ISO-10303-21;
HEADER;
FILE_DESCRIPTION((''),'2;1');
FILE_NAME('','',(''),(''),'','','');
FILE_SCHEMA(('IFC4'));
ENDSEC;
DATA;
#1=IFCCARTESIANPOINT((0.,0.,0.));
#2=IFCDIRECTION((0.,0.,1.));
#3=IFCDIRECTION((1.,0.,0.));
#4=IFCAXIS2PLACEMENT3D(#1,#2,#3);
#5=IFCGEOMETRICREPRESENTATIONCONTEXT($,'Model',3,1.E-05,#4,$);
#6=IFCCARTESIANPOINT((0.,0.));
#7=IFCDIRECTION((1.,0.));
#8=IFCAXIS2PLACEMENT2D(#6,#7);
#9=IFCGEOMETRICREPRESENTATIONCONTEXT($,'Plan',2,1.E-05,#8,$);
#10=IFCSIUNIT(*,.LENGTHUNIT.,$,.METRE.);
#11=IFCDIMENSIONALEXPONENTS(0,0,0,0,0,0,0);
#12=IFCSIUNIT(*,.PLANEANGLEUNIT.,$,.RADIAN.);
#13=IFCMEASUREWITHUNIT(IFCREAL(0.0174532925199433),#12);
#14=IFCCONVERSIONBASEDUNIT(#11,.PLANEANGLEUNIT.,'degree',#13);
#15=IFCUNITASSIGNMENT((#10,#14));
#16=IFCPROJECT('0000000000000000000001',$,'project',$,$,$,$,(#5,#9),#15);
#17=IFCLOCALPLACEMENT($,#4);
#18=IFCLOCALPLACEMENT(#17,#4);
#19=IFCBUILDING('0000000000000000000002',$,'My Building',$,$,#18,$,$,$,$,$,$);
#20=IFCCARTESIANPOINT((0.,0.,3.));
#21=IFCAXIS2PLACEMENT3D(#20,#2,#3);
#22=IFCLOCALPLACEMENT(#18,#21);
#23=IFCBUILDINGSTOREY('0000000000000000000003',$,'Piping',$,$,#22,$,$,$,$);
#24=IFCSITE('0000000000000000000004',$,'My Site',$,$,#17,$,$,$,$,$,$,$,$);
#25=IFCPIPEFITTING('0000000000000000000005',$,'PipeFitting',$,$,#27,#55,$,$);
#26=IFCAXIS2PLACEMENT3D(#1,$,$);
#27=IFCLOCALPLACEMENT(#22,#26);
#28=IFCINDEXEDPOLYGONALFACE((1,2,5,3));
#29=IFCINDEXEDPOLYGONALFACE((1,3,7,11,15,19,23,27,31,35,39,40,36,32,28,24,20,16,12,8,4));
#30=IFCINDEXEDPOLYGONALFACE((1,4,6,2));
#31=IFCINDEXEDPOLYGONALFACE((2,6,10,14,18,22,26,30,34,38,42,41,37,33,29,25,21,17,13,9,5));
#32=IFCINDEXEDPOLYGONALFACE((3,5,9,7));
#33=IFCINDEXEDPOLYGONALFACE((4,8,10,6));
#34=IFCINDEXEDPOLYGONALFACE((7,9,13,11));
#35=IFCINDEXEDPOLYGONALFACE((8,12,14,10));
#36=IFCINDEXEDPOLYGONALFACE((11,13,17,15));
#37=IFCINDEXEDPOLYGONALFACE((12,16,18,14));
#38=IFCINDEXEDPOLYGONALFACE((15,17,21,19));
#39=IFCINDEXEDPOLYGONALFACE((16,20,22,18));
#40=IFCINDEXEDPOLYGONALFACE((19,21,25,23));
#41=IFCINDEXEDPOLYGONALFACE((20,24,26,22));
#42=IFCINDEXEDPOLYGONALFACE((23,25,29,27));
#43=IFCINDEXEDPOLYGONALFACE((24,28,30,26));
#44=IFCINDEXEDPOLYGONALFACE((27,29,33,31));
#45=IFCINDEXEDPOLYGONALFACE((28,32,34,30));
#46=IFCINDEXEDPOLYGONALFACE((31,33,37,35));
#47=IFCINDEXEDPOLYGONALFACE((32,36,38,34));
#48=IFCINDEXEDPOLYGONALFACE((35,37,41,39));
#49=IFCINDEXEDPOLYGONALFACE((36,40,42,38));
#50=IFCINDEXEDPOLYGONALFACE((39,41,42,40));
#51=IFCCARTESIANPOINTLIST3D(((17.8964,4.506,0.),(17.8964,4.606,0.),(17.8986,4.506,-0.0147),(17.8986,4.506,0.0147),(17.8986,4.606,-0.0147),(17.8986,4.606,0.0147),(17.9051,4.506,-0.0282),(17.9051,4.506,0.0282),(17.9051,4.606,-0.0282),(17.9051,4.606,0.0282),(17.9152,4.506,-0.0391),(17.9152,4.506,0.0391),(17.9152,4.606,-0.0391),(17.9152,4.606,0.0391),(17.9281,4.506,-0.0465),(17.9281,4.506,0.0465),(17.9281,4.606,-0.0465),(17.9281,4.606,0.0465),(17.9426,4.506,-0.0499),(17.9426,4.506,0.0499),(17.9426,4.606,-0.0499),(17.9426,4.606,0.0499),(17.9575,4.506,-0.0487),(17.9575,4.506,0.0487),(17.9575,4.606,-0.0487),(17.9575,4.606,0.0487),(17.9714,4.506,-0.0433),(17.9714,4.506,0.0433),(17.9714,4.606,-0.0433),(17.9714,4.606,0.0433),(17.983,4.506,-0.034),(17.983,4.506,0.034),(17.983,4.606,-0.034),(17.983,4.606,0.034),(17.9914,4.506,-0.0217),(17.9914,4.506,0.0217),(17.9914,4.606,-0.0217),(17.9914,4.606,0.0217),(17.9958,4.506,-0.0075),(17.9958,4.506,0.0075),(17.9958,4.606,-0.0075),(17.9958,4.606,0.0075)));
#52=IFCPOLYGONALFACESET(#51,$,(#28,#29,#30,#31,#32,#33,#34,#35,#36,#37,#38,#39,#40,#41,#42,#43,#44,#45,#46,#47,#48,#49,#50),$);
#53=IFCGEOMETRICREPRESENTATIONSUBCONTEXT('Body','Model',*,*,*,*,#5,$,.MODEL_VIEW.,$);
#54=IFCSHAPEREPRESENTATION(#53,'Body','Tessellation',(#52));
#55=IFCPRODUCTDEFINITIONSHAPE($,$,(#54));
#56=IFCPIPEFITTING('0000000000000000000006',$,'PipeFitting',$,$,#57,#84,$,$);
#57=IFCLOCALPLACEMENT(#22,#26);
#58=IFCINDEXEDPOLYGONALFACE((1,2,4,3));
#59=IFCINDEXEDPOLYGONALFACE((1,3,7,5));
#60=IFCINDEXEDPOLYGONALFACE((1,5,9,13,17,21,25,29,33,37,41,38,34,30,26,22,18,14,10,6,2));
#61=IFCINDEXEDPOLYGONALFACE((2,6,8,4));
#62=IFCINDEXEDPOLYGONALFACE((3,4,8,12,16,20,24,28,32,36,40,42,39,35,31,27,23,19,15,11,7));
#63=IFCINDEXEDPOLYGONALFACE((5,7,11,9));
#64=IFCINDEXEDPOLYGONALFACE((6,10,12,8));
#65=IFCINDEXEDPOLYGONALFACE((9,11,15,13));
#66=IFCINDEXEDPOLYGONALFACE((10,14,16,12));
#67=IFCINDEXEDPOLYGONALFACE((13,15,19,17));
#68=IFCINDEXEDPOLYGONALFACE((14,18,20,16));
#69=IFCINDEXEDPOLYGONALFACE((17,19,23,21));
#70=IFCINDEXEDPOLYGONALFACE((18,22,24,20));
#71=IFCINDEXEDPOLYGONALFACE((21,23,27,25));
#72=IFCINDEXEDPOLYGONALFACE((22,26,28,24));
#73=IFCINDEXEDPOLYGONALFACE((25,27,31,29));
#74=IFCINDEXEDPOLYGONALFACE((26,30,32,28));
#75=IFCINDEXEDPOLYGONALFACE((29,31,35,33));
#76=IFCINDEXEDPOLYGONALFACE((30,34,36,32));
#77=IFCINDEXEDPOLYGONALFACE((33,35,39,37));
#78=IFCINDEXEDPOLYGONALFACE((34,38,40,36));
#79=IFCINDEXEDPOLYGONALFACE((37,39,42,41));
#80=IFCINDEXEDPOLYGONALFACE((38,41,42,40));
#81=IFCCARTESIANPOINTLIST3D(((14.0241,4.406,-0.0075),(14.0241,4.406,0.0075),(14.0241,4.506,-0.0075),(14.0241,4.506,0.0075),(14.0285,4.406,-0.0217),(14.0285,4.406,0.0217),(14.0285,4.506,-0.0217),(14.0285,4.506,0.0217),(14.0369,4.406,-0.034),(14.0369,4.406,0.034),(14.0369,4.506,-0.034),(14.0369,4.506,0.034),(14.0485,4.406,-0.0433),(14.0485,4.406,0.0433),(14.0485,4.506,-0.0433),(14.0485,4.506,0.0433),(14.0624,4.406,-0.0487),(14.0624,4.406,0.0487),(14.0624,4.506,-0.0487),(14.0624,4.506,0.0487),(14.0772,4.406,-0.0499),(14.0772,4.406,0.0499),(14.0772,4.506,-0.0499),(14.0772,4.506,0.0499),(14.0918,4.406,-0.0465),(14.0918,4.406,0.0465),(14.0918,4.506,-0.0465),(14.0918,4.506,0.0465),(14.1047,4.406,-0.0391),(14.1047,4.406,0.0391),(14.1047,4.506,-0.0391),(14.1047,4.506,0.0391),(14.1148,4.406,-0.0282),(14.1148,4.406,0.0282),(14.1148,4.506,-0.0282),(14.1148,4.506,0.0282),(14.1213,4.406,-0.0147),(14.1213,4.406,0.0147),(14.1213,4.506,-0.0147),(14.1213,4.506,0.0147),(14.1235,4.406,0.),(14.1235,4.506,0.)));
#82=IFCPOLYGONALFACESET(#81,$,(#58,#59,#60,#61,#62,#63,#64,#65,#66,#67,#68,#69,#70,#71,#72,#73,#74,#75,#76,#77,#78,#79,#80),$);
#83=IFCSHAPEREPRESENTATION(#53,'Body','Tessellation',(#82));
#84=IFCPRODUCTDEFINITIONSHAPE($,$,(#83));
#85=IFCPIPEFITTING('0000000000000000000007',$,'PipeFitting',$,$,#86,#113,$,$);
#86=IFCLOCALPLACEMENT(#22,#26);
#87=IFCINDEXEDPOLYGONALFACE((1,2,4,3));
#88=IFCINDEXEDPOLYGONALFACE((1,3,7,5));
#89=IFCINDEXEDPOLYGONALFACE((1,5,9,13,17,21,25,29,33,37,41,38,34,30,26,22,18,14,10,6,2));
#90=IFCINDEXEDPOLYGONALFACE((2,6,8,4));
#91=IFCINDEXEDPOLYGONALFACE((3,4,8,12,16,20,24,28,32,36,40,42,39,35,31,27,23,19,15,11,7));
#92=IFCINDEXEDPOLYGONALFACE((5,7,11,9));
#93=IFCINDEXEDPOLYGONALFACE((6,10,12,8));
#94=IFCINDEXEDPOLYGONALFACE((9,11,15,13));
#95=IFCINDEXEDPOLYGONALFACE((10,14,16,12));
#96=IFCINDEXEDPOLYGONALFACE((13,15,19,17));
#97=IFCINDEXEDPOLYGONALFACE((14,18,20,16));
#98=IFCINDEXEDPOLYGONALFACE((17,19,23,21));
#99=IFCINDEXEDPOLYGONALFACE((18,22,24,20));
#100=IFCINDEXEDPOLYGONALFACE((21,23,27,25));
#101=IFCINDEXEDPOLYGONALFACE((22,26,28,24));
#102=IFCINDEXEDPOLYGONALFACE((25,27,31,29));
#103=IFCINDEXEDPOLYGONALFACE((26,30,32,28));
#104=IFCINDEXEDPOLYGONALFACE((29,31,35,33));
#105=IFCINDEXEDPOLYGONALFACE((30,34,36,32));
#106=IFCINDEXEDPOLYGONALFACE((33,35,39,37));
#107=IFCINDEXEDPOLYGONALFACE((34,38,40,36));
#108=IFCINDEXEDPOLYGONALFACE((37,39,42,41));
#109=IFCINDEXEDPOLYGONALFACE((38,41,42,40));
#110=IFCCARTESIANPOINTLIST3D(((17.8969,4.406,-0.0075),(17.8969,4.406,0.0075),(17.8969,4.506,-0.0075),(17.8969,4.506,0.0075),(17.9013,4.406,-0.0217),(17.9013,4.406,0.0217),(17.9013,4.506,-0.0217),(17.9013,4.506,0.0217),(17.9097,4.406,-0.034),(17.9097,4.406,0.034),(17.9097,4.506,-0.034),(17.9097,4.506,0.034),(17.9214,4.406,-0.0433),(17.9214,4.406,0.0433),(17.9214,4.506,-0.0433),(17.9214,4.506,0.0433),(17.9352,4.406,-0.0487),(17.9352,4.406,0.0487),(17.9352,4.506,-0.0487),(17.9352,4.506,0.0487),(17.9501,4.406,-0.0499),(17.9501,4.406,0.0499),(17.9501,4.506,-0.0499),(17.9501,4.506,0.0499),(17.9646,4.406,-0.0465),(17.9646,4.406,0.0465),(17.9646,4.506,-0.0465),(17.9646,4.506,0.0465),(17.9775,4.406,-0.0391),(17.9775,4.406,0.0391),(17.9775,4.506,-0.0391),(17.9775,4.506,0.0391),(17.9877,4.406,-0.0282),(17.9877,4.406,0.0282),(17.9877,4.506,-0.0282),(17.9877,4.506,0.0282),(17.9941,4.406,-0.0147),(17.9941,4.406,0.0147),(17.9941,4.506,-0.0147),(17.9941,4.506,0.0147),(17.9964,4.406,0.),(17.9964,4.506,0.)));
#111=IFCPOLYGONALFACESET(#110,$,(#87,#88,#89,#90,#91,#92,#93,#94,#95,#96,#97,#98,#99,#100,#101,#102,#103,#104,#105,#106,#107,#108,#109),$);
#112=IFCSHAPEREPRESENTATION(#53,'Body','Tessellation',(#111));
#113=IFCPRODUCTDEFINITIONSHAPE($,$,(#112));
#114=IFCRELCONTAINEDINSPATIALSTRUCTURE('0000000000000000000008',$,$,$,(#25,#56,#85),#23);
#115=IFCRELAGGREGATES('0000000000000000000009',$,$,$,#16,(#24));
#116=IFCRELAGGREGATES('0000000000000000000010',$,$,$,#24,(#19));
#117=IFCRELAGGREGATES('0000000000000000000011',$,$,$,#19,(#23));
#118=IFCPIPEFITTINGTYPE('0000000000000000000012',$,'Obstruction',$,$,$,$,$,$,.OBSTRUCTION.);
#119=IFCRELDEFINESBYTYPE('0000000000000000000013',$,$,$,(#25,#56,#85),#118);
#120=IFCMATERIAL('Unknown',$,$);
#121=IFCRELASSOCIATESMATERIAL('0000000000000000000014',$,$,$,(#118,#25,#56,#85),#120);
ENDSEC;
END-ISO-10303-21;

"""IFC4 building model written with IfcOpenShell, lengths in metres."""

from ifc_helpers import new_model, entity, si_unit, converted_unit, frame, origin_with_axes, origin_2d_with_axis, place, context, subcontext, project, spatial, circle, extrude, material, material_profile, profile_set, profile_usage, type_object, element, save


model = new_model("IFC4")

# Units and contexts
model_context = context("Model", 3, precision=1e-05, world=origin_with_axes())
plan_context = context("Plan", 2, precision=1e-05, world=origin_2d_with_axis())
body_context = subcontext(model_context, "Body", "Model", "MODEL_VIEW")
ifc_project = project(units=[si_unit("LENGTHUNIT", "METRE"), converted_unit("PLANEANGLEUNIT", "degree", entity("IfcReal", 0.0174532925199433), si_unit("PLANEANGLEUNIT", "RADIAN"), dimensions=[0, 0, 0, 0, 0, 0, 0])], contexts=[model_context, plan_context])

# Site, building, storey
site_placement = place(None, origin_with_axes())
site = spatial("IfcSite", under=ifc_project, at=site_placement, Name="My Site")
building_placement = place(site_placement, origin_with_axes())
building = spatial("IfcBuilding", under=site, at=building_placement, Name="My Building")
storey_placement = place(building_placement, frame((0.0, 0.0, 3.0), z_axis=(0.0, 0.0, 1.0), x_axis=(1.0, 0.0, 0.0)))
storey = spatial("IfcBuildingStorey", under=building, at=storey_placement, Name="Piping")

# Shared definitions
ifc_material = material(Name="Unknown")

# Pipe fittings
ifc_material_profile_1 = material_profile(ifc_material, circle(Radius=0.05))
ifc_profile_set_1 = profile_set([ifc_material_profile_1])
pipe_fitting_type_1 = type_object("IfcPipeFittingType", Name="Obstruction", PredefinedType="OBSTRUCTION", material=ifc_profile_set_1)
ifc_profile_usage_1 = profile_usage(ifc_profile_set_1, cardinal=5)
pipe_fitting_1_placement = place(storey_placement, frame((17.9464, 4.506, 0.0), z_axis=(0.0, 1.0, 0.0), x_axis=(-1.0, 0.0, 0.0)))
element("IfcPipeFitting", 1, at=pipe_fitting_1_placement, inside=storey, type_object=pipe_fitting_type_1, material=ifc_profile_usage_1, Name="PipeFitting", context=body_context, shape_type="SweptSolid", body=[
    extrude(circle(Radius=0.05), origin_with_axes(), (0.0, 0.0, 1.0), 0.1),
])
ifc_profile_usage_2 = profile_usage(ifc_profile_set_1, cardinal=5)
pipe_fitting_2_placement = place(storey_placement, frame((14.0735, 4.506, 0.0), z_axis=(0.0, -1.0, 0.0), x_axis=(1.0, 0.0, 0.0)))
element("IfcPipeFitting", 2, at=pipe_fitting_2_placement, inside=storey, type_object=pipe_fitting_type_1, material=ifc_profile_usage_2, Name="PipeFitting", context=body_context, shape_type="SweptSolid", body=[
    extrude(circle(Radius=0.05), origin_with_axes(), (0.0, 0.0, 1.0), 0.1),
])
ifc_profile_usage_3 = profile_usage(ifc_profile_set_1, cardinal=5)
pipe_fitting_3_placement = place(storey_placement, frame((17.9464, 4.506, 0.0), z_axis=(0.0, -1.0, 0.0), x_axis=(1.0, 0.0, 0.0)))
element("IfcPipeFitting", 3, at=pipe_fitting_3_placement, inside=storey, type_object=pipe_fitting_type_1, material=ifc_profile_usage_3, Name="PipeFitting", context=body_context, shape_type="SweptSolid", body=[
    extrude(circle(Radius=0.05), origin_with_axes(), (0.0, 0.0, 1.0), 0.1),
])

save(model, "model.ifc")
